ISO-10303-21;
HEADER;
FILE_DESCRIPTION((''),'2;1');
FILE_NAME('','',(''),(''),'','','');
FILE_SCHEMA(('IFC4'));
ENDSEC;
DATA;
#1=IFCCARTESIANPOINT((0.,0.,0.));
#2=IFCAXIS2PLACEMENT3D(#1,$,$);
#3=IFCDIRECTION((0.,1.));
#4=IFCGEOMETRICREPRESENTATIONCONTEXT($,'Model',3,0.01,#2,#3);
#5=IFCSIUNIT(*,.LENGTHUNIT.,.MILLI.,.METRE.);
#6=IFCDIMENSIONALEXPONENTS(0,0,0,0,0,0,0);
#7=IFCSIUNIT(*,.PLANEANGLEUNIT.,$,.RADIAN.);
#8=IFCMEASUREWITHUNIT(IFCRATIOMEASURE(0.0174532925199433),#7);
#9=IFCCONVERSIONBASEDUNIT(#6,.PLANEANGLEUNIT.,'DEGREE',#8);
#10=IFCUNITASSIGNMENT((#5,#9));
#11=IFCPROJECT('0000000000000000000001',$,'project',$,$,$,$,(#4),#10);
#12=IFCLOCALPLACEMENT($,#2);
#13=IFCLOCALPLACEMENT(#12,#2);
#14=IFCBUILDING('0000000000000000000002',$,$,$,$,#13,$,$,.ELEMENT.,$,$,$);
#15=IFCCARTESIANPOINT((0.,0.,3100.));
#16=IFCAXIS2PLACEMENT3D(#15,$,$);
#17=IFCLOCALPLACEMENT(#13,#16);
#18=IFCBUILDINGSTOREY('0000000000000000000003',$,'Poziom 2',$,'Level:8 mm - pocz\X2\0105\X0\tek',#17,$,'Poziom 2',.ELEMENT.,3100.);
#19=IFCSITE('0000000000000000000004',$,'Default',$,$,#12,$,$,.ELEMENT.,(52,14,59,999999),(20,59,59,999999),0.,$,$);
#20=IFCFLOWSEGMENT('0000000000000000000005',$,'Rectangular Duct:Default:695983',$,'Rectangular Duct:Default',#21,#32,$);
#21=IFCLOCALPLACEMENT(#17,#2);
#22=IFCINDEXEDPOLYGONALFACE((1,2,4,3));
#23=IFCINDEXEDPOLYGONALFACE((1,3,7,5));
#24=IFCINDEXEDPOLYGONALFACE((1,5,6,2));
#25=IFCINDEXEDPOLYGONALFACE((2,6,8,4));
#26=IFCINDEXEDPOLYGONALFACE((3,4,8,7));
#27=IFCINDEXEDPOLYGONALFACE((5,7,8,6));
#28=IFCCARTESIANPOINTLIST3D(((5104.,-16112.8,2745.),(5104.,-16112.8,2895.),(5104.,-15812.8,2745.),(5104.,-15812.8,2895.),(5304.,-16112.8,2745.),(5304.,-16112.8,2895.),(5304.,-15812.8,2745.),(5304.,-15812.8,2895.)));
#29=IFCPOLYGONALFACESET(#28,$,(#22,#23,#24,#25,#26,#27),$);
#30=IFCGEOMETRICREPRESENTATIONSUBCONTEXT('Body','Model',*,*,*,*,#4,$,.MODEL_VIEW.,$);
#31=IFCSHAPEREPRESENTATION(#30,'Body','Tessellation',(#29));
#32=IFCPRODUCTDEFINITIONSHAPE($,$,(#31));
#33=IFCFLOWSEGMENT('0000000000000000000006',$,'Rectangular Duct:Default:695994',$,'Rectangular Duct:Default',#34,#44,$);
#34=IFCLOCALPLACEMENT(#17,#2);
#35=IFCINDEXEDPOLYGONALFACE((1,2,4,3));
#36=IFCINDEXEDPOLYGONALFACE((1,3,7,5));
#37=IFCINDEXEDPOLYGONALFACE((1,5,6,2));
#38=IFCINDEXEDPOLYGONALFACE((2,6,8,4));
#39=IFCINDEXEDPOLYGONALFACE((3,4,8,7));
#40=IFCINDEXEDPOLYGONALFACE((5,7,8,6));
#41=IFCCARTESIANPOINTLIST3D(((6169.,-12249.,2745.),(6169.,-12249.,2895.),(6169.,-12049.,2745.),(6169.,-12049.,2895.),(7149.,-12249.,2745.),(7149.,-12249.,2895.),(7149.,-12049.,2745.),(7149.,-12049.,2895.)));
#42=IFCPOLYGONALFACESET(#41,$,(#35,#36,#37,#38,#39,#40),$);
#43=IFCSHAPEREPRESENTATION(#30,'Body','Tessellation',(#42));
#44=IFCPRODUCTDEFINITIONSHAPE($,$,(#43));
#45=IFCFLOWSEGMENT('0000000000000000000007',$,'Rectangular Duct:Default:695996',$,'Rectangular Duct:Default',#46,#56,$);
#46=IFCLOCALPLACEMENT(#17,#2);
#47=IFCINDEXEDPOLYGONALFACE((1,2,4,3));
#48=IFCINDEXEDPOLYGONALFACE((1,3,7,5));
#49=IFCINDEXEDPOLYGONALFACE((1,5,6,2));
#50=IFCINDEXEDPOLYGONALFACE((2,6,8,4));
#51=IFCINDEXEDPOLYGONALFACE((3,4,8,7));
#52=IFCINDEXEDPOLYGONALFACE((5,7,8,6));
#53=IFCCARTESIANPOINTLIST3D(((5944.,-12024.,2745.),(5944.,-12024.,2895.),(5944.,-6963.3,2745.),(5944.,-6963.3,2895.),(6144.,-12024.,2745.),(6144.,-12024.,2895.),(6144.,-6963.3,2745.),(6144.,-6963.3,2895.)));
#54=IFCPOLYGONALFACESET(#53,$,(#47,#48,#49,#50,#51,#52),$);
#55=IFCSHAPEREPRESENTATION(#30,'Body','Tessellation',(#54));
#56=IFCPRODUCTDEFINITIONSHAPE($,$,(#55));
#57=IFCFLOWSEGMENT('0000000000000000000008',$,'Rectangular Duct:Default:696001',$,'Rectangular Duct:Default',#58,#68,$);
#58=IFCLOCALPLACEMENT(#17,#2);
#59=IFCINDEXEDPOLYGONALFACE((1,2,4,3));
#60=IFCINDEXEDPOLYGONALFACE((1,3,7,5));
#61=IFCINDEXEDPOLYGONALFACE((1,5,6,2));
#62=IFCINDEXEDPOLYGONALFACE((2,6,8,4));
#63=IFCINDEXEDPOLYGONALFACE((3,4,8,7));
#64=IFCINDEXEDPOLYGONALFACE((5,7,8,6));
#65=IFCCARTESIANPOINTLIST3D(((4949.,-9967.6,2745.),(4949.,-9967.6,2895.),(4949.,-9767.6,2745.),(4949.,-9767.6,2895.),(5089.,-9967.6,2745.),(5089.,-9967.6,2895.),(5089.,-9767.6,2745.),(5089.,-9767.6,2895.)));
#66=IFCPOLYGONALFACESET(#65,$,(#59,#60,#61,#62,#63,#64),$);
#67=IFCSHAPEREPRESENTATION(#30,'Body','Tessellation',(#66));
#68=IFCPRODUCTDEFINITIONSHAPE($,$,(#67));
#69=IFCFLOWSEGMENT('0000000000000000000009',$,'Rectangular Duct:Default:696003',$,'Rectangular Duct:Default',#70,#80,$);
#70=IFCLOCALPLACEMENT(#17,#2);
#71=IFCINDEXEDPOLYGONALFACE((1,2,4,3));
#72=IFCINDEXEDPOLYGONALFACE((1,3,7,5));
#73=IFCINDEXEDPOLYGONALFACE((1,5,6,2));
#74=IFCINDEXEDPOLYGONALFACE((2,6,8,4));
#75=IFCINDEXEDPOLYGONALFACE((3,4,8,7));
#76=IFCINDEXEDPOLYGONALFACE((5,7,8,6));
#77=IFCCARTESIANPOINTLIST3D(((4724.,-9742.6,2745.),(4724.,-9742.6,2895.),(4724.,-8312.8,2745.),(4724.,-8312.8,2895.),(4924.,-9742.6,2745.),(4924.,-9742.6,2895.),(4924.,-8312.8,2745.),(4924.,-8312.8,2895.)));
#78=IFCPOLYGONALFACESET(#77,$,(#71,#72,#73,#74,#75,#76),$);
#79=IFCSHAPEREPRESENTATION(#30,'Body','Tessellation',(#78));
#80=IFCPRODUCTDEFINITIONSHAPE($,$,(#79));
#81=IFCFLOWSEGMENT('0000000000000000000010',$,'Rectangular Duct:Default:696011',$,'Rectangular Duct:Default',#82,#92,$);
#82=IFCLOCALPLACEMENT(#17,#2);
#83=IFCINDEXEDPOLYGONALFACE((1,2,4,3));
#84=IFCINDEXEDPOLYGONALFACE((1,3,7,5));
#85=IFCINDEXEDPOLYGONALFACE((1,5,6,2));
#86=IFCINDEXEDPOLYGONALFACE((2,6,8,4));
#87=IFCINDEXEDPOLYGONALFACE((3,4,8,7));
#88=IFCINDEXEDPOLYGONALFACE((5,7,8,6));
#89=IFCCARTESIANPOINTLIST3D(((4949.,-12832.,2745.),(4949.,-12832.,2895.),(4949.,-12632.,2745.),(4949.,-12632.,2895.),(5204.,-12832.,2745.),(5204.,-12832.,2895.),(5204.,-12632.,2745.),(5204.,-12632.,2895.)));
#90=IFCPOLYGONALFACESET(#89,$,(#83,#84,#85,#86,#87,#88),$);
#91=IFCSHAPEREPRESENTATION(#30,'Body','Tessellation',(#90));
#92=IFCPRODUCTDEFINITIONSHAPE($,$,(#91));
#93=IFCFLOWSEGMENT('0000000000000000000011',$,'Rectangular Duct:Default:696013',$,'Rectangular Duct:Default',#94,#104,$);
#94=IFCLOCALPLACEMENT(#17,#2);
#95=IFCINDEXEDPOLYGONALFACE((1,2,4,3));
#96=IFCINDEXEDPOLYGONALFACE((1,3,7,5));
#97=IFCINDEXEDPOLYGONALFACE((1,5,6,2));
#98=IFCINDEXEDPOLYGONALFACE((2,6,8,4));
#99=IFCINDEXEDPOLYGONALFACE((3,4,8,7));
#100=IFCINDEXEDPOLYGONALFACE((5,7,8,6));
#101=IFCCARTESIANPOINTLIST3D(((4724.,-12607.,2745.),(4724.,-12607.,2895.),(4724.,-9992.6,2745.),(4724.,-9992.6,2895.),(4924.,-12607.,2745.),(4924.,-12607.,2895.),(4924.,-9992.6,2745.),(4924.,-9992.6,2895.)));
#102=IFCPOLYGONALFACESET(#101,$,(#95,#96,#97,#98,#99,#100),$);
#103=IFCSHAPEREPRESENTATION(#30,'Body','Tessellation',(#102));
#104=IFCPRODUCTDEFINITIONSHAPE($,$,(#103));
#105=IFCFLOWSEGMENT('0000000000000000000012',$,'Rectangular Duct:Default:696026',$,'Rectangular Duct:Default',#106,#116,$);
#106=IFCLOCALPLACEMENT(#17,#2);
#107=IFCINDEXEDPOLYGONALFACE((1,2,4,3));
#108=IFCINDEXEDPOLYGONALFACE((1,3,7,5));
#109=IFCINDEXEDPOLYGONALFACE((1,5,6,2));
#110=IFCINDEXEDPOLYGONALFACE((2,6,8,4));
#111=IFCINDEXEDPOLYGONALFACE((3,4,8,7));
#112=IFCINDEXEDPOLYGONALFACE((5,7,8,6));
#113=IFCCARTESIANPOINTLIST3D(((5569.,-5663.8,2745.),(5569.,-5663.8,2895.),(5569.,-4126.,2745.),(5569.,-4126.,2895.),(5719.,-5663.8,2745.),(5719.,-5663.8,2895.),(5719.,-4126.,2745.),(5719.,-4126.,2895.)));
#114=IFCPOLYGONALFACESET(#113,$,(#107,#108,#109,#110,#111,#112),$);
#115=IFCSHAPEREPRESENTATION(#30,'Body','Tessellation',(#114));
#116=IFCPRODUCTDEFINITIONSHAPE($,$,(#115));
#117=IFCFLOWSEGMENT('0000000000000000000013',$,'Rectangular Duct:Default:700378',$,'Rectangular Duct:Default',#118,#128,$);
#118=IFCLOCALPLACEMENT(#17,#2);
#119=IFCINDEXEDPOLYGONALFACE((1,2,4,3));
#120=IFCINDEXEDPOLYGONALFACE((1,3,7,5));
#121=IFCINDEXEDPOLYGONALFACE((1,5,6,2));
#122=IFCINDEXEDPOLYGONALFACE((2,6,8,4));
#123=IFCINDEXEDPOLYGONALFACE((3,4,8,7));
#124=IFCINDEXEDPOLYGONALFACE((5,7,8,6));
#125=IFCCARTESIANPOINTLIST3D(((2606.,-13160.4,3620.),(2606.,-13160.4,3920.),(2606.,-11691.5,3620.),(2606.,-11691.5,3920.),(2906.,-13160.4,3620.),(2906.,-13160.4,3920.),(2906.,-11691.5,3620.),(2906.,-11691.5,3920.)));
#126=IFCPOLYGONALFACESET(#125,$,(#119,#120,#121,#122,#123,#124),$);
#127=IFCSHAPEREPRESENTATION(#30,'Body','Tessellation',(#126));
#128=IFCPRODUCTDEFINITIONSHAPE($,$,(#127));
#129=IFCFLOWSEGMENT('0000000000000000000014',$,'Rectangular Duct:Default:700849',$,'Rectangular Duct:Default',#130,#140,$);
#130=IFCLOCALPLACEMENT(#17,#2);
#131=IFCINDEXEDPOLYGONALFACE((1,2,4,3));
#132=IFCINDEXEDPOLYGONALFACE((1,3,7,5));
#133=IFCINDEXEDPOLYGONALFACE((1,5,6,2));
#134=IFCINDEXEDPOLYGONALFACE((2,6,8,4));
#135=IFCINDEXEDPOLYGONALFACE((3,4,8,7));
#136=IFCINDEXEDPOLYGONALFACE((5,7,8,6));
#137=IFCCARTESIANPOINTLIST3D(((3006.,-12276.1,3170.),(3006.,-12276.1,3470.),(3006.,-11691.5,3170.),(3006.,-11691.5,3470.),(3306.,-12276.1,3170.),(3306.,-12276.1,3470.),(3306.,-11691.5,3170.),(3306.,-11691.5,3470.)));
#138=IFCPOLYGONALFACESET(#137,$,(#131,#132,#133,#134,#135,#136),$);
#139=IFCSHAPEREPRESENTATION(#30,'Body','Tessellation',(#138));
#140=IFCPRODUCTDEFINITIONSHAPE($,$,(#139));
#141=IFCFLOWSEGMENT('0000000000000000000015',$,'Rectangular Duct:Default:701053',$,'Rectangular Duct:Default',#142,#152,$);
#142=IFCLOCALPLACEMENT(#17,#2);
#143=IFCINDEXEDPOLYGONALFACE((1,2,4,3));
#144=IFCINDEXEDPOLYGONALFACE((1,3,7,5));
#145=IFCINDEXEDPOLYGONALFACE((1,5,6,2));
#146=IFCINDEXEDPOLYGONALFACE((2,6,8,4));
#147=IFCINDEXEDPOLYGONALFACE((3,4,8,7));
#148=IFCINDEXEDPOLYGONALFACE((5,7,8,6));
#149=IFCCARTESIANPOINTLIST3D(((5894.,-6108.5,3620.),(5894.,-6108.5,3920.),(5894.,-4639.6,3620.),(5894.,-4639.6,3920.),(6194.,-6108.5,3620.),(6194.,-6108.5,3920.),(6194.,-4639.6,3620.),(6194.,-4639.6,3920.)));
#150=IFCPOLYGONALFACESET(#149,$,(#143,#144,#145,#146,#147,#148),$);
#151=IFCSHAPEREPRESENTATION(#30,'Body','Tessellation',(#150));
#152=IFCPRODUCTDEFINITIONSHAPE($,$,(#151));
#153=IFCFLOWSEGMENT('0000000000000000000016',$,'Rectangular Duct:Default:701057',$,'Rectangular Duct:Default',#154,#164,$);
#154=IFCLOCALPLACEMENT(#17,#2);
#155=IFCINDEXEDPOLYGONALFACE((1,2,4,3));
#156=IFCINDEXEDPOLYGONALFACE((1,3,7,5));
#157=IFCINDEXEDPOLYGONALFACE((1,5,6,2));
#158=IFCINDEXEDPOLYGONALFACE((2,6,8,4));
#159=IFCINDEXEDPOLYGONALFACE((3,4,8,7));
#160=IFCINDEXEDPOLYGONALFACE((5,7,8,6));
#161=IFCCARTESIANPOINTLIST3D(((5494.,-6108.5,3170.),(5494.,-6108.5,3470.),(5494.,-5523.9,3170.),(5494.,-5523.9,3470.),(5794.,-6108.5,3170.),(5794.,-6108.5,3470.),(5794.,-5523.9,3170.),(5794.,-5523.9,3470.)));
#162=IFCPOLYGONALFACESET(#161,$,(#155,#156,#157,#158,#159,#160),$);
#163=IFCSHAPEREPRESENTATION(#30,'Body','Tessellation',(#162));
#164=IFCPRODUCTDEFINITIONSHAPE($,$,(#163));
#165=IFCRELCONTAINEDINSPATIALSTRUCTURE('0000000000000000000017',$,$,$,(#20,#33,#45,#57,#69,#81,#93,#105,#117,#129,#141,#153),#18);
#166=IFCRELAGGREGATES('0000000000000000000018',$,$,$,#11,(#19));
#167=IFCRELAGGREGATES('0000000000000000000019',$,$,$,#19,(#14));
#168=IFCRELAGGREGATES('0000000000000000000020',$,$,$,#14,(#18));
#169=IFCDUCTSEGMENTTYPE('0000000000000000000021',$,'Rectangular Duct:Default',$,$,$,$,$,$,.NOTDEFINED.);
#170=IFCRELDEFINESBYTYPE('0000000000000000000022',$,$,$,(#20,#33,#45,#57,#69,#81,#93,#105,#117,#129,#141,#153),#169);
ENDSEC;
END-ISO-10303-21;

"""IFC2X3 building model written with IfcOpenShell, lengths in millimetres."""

from ifc_helpers import new_model, entity, si_unit, converted_unit, direction, frame, frame_2d, origin, origin_2d_with_axis, place, context, subcontext, project, spatial, rectangle, extrude, type_object, element, save


model = new_model("IFC2X3")

# Units and contexts
model_context = context("Model", 3, precision=0.01, world=origin(), true_north=direction((0.0, 1.0)))
body_context = subcontext(model_context, "Body", "Model", "MODEL_VIEW")
ifc_project = project(units=[si_unit("LENGTHUNIT", "METRE", prefix="MILLI"), converted_unit("PLANEANGLEUNIT", "DEGREE", entity("IfcRatioMeasure", 0.0174532925199433), si_unit("PLANEANGLEUNIT", "RADIAN"), dimensions=[0, 0, 0, 0, 0, 0, 0])], contexts=[model_context])

# Site, building, storey
site_placement = place(None, origin())
site = spatial("IfcSite", under=ifc_project, at=site_placement, Name="Default", CompositionType="ELEMENT", RefLatitude=(52, 14, 59, 999999), RefLongitude=(20, 59, 59, 999999), RefElevation=0.0)
building_placement = place(site_placement, origin())
building = spatial("IfcBuilding", under=site, at=building_placement, CompositionType="ELEMENT")
storey_placement = place(building_placement, frame((0.0, 0.0, 3100.0)))
storey = spatial("IfcBuildingStorey", under=building, at=storey_placement, Name="Poziom 2", ObjectType="Level:8 mm - początek", LongName="Poziom 2", CompositionType="ELEMENT", Elevation=3100.0)

# Flow segments
duct_segment_type = type_object("IfcDuctSegmentType", Name="Rectangular Duct:Default", PredefinedType="NOTDEFINED")
flow_segment_1_placement = place(storey_placement, origin())
element("IfcFlowSegment", 1, at=flow_segment_1_placement, inside=storey, type_object=duct_segment_type, Name="Rectangular Duct:Default:695983", ObjectType="Rectangular Duct:Default", context=body_context, shape_type="SweptSolid", body=[
    extrude(rectangle(XDim=300.0, YDim=200.0, at=frame_2d((0.0, 0.0), x_axis=(1.0, 0.0))), frame((5204.0, -15962.8, 2745.0), z_axis=(0.0, 0.0, 1.0), x_axis=(0.0, -1.0, 0.0)), (0.0, 0.0, 1.0), 150.0),
])
flow_segment_2_placement = place(storey_placement, origin())
element("IfcFlowSegment", 2, at=flow_segment_2_placement, inside=storey, type_object=duct_segment_type, Name="Rectangular Duct:Default:695994", ObjectType="Rectangular Duct:Default", context=body_context, shape_type="SweptSolid", body=[
    extrude(rectangle(XDim=980.0, YDim=200.0, at=origin_2d_with_axis()), frame((6659.0, -12149.0, 2745.0)), (0.0, 0.0, 1.0), 150.0),
])
flow_segment_3_placement = place(storey_placement, origin())
element("IfcFlowSegment", 3, at=flow_segment_3_placement, inside=storey, type_object=duct_segment_type, Name="Rectangular Duct:Default:695996", ObjectType="Rectangular Duct:Default", context=body_context, shape_type="SweptSolid", body=[
    extrude(rectangle(XDim=5060.7, YDim=200.0, at=frame_2d((0.0, 0.0), x_axis=(1.0, 0.0))), frame((6044.0, -9493.6, 2745.0), z_axis=(0.0, 0.0, 1.0), x_axis=(0.0, -1.0, 0.0)), (0.0, 0.0, 1.0), 150.0),
])
flow_segment_4_placement = place(storey_placement, origin())
element("IfcFlowSegment", 4, at=flow_segment_4_placement, inside=storey, type_object=duct_segment_type, Name="Rectangular Duct:Default:696001", ObjectType="Rectangular Duct:Default", context=body_context, shape_type="SweptSolid", body=[
    extrude(rectangle(XDim=140.0, YDim=200.0, at=frame_2d((0.0, 0.0), x_axis=(1.0, 0.0))), frame((5019.0, -9867.6, 2745.0)), (0.0, 0.0, 1.0), 150.0),
])
flow_segment_5_placement = place(storey_placement, origin())
element("IfcFlowSegment", 5, at=flow_segment_5_placement, inside=storey, type_object=duct_segment_type, Name="Rectangular Duct:Default:696003", ObjectType="Rectangular Duct:Default", context=body_context, shape_type="SweptSolid", body=[
    extrude(rectangle(XDim=1429.8, YDim=200.0, at=origin_2d_with_axis()), frame((4824.0, -9027.7, 2745.0), z_axis=(0.0, 0.0, 1.0), x_axis=(0.0, -1.0, 0.0)), (0.0, 0.0, 1.0), 150.0),
])
flow_segment_6_placement = place(storey_placement, origin())
element("IfcFlowSegment", 6, at=flow_segment_6_placement, inside=storey, type_object=duct_segment_type, Name="Rectangular Duct:Default:696011", ObjectType="Rectangular Duct:Default", context=body_context, shape_type="SweptSolid", body=[
    extrude(rectangle(XDim=255.0, YDim=200.0, at=frame_2d((0.0, 0.0), x_axis=(1.0, 0.0))), frame((5076.5, -12732.0, 2745.0)), (0.0, 0.0, 1.0), 150.0),
])
flow_segment_7_placement = place(storey_placement, origin())
element("IfcFlowSegment", 7, at=flow_segment_7_placement, inside=storey, type_object=duct_segment_type, Name="Rectangular Duct:Default:696013", ObjectType="Rectangular Duct:Default", context=body_context, shape_type="SweptSolid", body=[
    extrude(rectangle(XDim=2614.4, YDim=200.0, at=frame_2d((0.0, 0.0), x_axis=(1.0, 0.0))), frame((4824.0, -11299.8, 2745.0), z_axis=(0.0, 0.0, 1.0), x_axis=(0.0, -1.0, 0.0)), (0.0, 0.0, 1.0), 150.0),
])
flow_segment_8_placement = place(storey_placement, origin())
element("IfcFlowSegment", 8, at=flow_segment_8_placement, inside=storey, type_object=duct_segment_type, Name="Rectangular Duct:Default:696026", ObjectType="Rectangular Duct:Default", context=body_context, shape_type="SweptSolid", body=[
    extrude(rectangle(XDim=1537.8, YDim=150.0, at=frame_2d((0.0, 0.0), x_axis=(1.0, 0.0))), frame((5644.0, -4894.9, 2745.0), z_axis=(0.0, 0.0, 1.0), x_axis=(0.0, 1.0, 0.0)), (0.0, 0.0, 1.0), 150.0),
])
flow_segment_9_placement = place(storey_placement, origin())
element("IfcFlowSegment", 9, at=flow_segment_9_placement, inside=storey, type_object=duct_segment_type, Name="Rectangular Duct:Default:700378", ObjectType="Rectangular Duct:Default", context=body_context, shape_type="SweptSolid", body=[
    extrude(rectangle(XDim=1468.9, YDim=300.0, at=frame_2d((0.0, 0.0), x_axis=(1.0, 0.0))), frame((2756.0, -12425.9, 3620.0), z_axis=(0.0, 0.0, 1.0), x_axis=(0.0, -1.0, 0.0)), (0.0, 0.0, 1.0), 300.0),
])
flow_segment_10_placement = place(storey_placement, origin())
element("IfcFlowSegment", 10, at=flow_segment_10_placement, inside=storey, type_object=duct_segment_type, Name="Rectangular Duct:Default:700849", ObjectType="Rectangular Duct:Default", context=body_context, shape_type="SweptSolid", body=[
    extrude(rectangle(XDim=584.6, YDim=300.0, at=frame_2d((0.0, 0.0), x_axis=(1.0, 0.0))), frame((3156.0, -11983.8, 3170.0), z_axis=(0.0, 0.0, 1.0), x_axis=(0.0, -1.0, 0.0)), (0.0, 0.0, 1.0), 300.0),
])
flow_segment_11_placement = place(storey_placement, origin())
element("IfcFlowSegment", 11, at=flow_segment_11_placement, inside=storey, type_object=duct_segment_type, Name="Rectangular Duct:Default:701053", ObjectType="Rectangular Duct:Default", context=body_context, shape_type="SweptSolid", body=[
    extrude(rectangle(XDim=1468.9, YDim=300.0, at=frame_2d((0.0, 0.0), x_axis=(1.0, 0.0))), frame((6044.0, -5374.1, 3620.0), z_axis=(0.0, 0.0, 1.0), x_axis=(0.0, 1.0, 0.0)), (0.0, 0.0, 1.0), 300.0),
])
flow_segment_12_placement = place(storey_placement, origin())
element("IfcFlowSegment", 12, at=flow_segment_12_placement, inside=storey, type_object=duct_segment_type, Name="Rectangular Duct:Default:701057", ObjectType="Rectangular Duct:Default", context=body_context, shape_type="SweptSolid", body=[
    extrude(rectangle(XDim=584.6, YDim=300.0, at=frame_2d((0.0, 0.0), x_axis=(1.0, 0.0))), frame((5644.0, -5816.2, 3170.0), z_axis=(0.0, 0.0, 1.0), x_axis=(0.0, 1.0, 0.0)), (0.0, 0.0, 1.0), 300.0),
])

save(model, "model.ifc")
